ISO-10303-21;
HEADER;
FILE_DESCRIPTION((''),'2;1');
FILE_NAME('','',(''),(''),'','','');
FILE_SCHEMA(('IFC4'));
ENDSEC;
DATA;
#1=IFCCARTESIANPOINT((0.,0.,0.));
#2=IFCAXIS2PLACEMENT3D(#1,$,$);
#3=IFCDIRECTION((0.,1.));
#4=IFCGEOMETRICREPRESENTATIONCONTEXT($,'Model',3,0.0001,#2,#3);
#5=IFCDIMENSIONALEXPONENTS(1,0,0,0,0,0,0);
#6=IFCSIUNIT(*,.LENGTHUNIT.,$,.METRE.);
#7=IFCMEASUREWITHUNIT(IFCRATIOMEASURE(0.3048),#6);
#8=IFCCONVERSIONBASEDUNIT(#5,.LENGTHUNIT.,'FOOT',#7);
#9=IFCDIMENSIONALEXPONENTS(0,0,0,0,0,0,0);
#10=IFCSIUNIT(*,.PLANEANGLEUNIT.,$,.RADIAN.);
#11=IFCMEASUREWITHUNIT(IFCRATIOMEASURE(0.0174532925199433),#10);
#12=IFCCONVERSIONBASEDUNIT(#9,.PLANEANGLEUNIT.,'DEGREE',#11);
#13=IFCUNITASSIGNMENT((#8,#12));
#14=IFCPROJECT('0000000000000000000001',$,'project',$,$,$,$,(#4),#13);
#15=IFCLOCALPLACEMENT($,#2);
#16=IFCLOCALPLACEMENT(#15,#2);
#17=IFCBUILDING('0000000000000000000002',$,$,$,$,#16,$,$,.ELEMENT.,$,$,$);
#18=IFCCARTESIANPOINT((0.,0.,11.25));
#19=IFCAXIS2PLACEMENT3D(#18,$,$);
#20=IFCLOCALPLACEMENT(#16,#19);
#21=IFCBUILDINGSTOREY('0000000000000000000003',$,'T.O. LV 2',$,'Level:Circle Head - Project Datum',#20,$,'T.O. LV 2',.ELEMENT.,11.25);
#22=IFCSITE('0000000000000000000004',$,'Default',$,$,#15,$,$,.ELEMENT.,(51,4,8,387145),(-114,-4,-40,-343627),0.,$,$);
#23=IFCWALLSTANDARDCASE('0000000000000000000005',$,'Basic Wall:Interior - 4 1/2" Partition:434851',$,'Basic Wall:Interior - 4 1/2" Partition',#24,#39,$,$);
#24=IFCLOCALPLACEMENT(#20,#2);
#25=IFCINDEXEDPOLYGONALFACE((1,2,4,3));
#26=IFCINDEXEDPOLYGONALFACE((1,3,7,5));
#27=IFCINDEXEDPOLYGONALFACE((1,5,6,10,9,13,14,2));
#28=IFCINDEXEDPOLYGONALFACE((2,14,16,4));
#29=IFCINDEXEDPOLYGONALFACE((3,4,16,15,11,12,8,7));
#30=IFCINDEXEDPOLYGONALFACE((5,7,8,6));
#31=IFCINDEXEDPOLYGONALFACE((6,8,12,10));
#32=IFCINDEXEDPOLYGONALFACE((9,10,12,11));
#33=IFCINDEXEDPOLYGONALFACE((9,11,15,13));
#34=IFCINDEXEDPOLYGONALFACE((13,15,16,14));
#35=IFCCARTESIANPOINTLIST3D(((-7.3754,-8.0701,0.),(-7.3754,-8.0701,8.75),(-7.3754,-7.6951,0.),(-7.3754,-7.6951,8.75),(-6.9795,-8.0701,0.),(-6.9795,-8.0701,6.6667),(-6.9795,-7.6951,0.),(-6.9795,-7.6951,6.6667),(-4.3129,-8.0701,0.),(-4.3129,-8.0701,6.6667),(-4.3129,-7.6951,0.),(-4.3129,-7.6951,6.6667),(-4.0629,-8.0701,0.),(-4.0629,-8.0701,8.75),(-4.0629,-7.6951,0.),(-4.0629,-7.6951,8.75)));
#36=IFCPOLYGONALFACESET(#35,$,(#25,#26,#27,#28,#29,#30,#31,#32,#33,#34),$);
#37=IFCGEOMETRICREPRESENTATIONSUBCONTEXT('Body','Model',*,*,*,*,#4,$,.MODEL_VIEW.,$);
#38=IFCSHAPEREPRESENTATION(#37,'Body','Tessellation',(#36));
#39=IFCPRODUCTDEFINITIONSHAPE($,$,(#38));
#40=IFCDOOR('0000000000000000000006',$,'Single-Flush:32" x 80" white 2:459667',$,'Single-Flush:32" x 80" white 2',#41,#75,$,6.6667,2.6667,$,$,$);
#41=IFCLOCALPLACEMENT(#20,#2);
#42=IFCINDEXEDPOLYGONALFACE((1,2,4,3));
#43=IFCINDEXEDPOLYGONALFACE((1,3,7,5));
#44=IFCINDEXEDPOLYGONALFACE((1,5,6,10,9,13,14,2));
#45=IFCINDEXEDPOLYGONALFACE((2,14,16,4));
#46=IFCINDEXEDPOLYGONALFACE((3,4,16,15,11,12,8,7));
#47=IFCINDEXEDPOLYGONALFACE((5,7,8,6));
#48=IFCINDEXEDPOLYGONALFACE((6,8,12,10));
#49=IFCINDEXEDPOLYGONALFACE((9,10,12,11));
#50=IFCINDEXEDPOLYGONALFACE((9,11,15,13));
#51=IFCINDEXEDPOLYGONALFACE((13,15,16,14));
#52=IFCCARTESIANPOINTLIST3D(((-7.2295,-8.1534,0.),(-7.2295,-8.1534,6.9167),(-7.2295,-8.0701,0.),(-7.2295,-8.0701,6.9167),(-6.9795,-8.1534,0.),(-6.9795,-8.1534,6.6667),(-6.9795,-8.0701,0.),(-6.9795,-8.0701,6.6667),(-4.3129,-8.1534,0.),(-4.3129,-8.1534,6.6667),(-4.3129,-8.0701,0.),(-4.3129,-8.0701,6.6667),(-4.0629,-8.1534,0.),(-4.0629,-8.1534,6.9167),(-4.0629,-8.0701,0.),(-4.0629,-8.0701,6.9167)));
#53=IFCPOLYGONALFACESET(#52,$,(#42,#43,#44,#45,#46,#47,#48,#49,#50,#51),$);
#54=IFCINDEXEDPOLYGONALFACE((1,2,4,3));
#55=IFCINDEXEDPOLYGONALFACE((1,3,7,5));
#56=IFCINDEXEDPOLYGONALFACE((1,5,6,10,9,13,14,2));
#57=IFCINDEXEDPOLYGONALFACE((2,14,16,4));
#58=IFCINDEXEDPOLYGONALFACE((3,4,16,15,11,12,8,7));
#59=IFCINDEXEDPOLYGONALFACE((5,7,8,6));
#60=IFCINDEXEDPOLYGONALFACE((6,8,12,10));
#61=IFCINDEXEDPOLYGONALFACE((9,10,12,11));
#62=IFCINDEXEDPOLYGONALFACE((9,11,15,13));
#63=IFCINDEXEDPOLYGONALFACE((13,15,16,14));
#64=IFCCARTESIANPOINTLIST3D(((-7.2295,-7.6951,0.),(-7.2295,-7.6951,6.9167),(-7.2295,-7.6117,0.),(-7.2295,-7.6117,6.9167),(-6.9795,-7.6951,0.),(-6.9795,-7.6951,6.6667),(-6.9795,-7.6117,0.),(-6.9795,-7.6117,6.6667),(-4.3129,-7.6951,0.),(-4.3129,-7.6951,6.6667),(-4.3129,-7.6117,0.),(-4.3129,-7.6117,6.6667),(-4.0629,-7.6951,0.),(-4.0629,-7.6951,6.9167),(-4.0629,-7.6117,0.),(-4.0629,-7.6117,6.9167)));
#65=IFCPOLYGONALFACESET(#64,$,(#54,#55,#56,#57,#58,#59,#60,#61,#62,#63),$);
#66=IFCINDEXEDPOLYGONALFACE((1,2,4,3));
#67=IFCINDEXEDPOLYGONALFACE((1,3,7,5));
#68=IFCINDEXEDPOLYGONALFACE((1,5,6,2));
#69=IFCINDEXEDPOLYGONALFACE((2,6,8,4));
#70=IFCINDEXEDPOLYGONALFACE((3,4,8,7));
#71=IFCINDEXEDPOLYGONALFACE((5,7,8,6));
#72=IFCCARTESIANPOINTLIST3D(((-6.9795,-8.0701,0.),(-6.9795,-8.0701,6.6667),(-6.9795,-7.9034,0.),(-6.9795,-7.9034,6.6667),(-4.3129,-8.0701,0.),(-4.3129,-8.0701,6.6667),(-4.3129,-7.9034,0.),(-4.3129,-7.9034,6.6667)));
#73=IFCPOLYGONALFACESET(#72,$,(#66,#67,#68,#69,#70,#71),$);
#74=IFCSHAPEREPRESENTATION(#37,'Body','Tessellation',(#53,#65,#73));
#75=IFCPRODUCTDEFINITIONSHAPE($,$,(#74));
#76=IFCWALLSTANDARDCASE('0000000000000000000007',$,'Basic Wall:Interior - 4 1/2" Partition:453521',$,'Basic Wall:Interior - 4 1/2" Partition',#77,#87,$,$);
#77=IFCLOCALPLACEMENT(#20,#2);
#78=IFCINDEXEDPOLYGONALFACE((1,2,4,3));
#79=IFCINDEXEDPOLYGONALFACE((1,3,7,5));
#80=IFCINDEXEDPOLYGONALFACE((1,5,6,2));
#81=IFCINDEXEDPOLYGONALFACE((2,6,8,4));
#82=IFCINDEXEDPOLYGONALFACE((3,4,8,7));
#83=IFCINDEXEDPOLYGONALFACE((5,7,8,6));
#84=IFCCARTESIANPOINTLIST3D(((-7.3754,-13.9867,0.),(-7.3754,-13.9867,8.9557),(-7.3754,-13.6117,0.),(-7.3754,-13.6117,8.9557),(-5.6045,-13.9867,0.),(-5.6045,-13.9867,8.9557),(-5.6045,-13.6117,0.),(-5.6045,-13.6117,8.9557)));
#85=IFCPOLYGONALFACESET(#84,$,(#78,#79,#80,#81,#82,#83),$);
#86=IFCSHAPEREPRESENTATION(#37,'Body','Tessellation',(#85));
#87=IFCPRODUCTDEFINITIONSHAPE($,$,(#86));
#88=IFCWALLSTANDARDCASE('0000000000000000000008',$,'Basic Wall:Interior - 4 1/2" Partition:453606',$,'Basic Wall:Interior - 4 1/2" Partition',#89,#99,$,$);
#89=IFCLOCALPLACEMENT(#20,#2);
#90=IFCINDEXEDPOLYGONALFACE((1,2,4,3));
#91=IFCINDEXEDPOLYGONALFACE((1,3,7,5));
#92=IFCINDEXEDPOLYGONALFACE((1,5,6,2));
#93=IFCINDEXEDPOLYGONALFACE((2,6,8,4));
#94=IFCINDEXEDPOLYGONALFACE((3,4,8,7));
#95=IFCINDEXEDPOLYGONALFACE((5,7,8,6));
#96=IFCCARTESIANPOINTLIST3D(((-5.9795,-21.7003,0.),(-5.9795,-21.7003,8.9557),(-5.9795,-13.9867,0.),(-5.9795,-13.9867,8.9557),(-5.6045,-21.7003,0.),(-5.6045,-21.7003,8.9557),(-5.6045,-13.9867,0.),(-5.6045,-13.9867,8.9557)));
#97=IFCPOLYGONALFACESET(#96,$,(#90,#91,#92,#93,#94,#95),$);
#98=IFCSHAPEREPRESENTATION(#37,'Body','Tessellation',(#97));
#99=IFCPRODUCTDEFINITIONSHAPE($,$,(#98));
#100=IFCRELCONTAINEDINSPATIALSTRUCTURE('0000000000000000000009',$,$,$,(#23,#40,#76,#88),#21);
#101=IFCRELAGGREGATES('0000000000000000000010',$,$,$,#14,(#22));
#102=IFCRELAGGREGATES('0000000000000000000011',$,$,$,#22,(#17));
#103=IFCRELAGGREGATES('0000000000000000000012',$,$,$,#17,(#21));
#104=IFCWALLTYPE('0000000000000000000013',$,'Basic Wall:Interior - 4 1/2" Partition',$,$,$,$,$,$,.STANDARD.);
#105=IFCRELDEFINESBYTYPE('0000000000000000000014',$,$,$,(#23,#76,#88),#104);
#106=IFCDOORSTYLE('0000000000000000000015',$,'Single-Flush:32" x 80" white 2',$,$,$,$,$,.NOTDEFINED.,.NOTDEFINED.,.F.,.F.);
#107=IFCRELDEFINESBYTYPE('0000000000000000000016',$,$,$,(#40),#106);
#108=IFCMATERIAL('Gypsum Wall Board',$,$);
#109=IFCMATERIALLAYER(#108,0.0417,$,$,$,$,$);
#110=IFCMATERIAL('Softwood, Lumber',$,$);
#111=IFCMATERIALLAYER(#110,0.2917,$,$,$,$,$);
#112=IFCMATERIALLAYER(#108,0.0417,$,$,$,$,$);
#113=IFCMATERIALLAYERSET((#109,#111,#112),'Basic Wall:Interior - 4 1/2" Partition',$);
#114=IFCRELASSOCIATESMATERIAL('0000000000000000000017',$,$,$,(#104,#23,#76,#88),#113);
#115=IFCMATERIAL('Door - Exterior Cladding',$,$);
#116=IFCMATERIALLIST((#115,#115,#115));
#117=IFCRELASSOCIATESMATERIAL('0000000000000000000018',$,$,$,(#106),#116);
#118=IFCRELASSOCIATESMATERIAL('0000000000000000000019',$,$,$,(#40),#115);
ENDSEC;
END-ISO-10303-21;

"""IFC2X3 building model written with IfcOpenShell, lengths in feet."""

from ifc_helpers import new_model, entity, si_unit, converted_unit, direction, frame, frame_2d, origin, place, context, subcontext, project, spatial, polyline, rectangle, outline, extrude, source, transform, mapped, material, material_list, layer, layer_set, layer_usage, type_object, type_shapes, element, fill, save


model = new_model("IFC2X3")

# Units and contexts
model_context = context("Model", 3, precision=0.0001, world=origin(), true_north=direction((0.0, 1.0)))
body_context = subcontext(model_context, "Body", "Model", "MODEL_VIEW")
ifc_project = project(units=[converted_unit("LENGTHUNIT", "FOOT", entity("IfcRatioMeasure", 0.3048), si_unit("LENGTHUNIT", "METRE"), dimensions=[1, 0, 0, 0, 0, 0, 0]), converted_unit("PLANEANGLEUNIT", "DEGREE", entity("IfcRatioMeasure", 0.0174532925199433), si_unit("PLANEANGLEUNIT", "RADIAN"), dimensions=[0, 0, 0, 0, 0, 0, 0])], contexts=[model_context])

# Site, building, storey
site_placement = place(None, origin())
site = spatial("IfcSite", under=ifc_project, at=site_placement, Name="Default", CompositionType="ELEMENT", RefLatitude=(51, 4, 8, 387145), RefLongitude=(-114, -4, -40, -343627), RefElevation=0.0)
building_placement = place(site_placement, origin())
building = spatial("IfcBuilding", under=site, at=building_placement, CompositionType="ELEMENT")
storey_placement = place(building_placement, frame((0.0, 0.0, 11.25)))
storey = spatial("IfcBuildingStorey", under=building, at=storey_placement, Name="T.O. LV 2", ObjectType="Level:Circle Head - Project Datum", LongName="T.O. LV 2", CompositionType="ELEMENT", Elevation=11.25)

# Shared definitions
ifc_material_1 = material(Name="Gypsum Wall Board")
ifc_layer_1 = layer(ifc_material_1, 0.0417)
ifc_material_2 = material(Name="Softwood, Lumber")
ifc_layer_2 = layer(ifc_material_2, 0.2917)
ifc_layer_3 = layer(ifc_material_1, 0.0417)
ifc_layer_set_1 = layer_set([ifc_layer_1, ifc_layer_2, ifc_layer_3], Name="Basic Wall:Interior - 4 1/2\" Partition")
wall_type_1 = type_object("IfcWallType", Name="Basic Wall:Interior - 4 1/2\" Partition", PredefinedType="STANDARD", material=ifc_layer_set_1)

# Wall, opening, door
ifc_material_3 = material(Name="Door - Exterior Cladding")
ifc_layer_usage_1 = layer_usage(ifc_layer_set_1, "AXIS2", "NEGATIVE", 0.1875)
wall_1_placement = place(storey_placement, frame((-7.3754, -7.8826, 0.0)))
wall_1 = element("IfcWallStandardCase", 1, at=wall_1_placement, inside=storey, type_object=wall_type_1, material=ifc_layer_usage_1, Name="Basic Wall:Interior - 4 1/2\" Partition:434851", ObjectType="Basic Wall:Interior - 4 1/2\" Partition", context=body_context, shape_type="SweptSolid", body=[
    extrude(rectangle(XDim=3.3125, YDim=0.375, at=frame_2d((1.6563, 0.0), x_axis=(-1.0, 0.0))), origin(), (0.0, 0.0, 1.0), 8.75),
])
opening_1_placement = place(wall_1_placement, frame((3.0625, 0.1875, 0.0)))
opening_1 = element("IfcOpeningElement", 2, at=opening_1_placement, cuts=wall_1, ObjectType="Opening", context=body_context, shape_type="SweptSolid", body=[
    extrude(rectangle(XDim=2.6667, YDim=6.6667, at=frame_2d((3.3333, 1.3333), x_axis=(0.0, 1.0))), frame((0.0, 0.0, 0.0), z_axis=(0.0, -1.0, 0.0), x_axis=(0.0, 0.0, 1.0)), (0.0, 0.0, 1.0), 0.375),
])
ifc_material_list_1 = material_list([ifc_material_3, ifc_material_3, ifc_material_3])
door_style_1 = type_object("IfcDoorStyle", Name="Single-Flush:32\" x 80\" white 2", ConstructionType="NOTDEFINED", OperationType="NOTDEFINED", ParameterTakesPrecedence=False, Sizeable=False, material=ifc_material_list_1)
shared_shape_1 = source(origin(), body_context, "Body", "SweptSolid", [
    extrude(outline(polyline([(-1.5833, -3.5208), (1.5833, -3.5208), (1.5833, 3.3958), (1.3333, 3.3958), (1.3333, -3.2708), (-1.3333, -3.2708), (-1.3333, 3.3958), (-1.5833, 3.3958), (-1.5833, -3.5208)])), frame((1.3333, 0.375, 3.3958), z_axis=(0.0, 1.0, 0.0), x_axis=(1.0, 0.0, 0.0)), (0.0, 0.0, 1.0), 0.0833),
    extrude(outline(polyline([(-3.5208, -1.5833), (3.3958, -1.5833), (3.3958, -1.3333), (-3.2708, -1.3333), (-3.2708, 1.3333), (3.3958, 1.3333), (3.3958, 1.5833), (-3.5208, 1.5833), (-3.5208, -1.5833)])), frame((1.3333, -0.0833, 3.3958), z_axis=(0.0, 1.0, 0.0), x_axis=(0.0, 0.0, -1.0)), (0.0, 0.0, 1.0), 0.0833),
    extrude(rectangle(XDim=0.1667, YDim=2.6667, at=frame_2d((0.0, 0.0), x_axis=(1.0, 0.0))), frame((1.3333, 0.2917, 0.0), z_axis=(0.0, 0.0, 1.0), x_axis=(0.0, 1.0, 0.0)), (0.0, 0.0, 1.0), 6.6667),
])
type_shapes(door_style_1, [shared_shape_1])
door_1_placement = place(opening_1_placement, frame((0.0, 0.0, 0.0), z_axis=(0.0, 0.0, 1.0), x_axis=(-1.0, 0.0, 0.0)))
door_1 = element("IfcDoor", 3, at=door_1_placement, inside=storey, type_object=door_style_1, material=ifc_material_3, Name="Single-Flush:32\" x 80\" white 2:459667", ObjectType="Single-Flush:32\" x 80\" white 2", OverallHeight=6.6667, OverallWidth=2.6667, context=body_context, shape_type="MappedRepresentation", body=[
    mapped(shared_shape_1, transform((0.0, 0.0, 0.0), scale=1.0)),
])
fill(opening_1, door_1)

# Walls
ifc_layer_usage_2 = layer_usage(ifc_layer_set_1, "AXIS2", "NEGATIVE", 0.1875)
wall_2_placement = place(storey_placement, frame((-7.3754, -13.7992, 0.0)))
element("IfcWallStandardCase", 4, at=wall_2_placement, inside=storey, type_object=wall_type_1, material=ifc_layer_usage_2, Name="Basic Wall:Interior - 4 1/2\" Partition:453521", ObjectType="Basic Wall:Interior - 4 1/2\" Partition", context=body_context, shape_type="SweptSolid", body=[
    extrude(rectangle(XDim=1.7708, YDim=0.375, at=frame_2d((0.8854, 0.0), x_axis=(-1.0, 0.0))), origin(), (0.0, 0.0, 1.0), 8.9557),
])
ifc_layer_usage_3 = layer_usage(ifc_layer_set_1, "AXIS2", "NEGATIVE", 0.1875)
wall_3_placement = place(storey_placement, frame((-5.792, -13.9867, 0.0), z_axis=(0.0, 0.0, 1.0), x_axis=(0.0, -1.0, 0.0)))
element("IfcWallStandardCase", 5, at=wall_3_placement, inside=storey, type_object=wall_type_1, material=ifc_layer_usage_3, Name="Basic Wall:Interior - 4 1/2\" Partition:453606", ObjectType="Basic Wall:Interior - 4 1/2\" Partition", context=body_context, shape_type="SweptSolid", body=[
    extrude(rectangle(XDim=7.7135, YDim=0.375, at=frame_2d((3.8568, 0.0), x_axis=(-1.0, 0.0))), origin(), (0.0, 0.0, 1.0), 8.9557),
])

save(model, "model.ifc")
